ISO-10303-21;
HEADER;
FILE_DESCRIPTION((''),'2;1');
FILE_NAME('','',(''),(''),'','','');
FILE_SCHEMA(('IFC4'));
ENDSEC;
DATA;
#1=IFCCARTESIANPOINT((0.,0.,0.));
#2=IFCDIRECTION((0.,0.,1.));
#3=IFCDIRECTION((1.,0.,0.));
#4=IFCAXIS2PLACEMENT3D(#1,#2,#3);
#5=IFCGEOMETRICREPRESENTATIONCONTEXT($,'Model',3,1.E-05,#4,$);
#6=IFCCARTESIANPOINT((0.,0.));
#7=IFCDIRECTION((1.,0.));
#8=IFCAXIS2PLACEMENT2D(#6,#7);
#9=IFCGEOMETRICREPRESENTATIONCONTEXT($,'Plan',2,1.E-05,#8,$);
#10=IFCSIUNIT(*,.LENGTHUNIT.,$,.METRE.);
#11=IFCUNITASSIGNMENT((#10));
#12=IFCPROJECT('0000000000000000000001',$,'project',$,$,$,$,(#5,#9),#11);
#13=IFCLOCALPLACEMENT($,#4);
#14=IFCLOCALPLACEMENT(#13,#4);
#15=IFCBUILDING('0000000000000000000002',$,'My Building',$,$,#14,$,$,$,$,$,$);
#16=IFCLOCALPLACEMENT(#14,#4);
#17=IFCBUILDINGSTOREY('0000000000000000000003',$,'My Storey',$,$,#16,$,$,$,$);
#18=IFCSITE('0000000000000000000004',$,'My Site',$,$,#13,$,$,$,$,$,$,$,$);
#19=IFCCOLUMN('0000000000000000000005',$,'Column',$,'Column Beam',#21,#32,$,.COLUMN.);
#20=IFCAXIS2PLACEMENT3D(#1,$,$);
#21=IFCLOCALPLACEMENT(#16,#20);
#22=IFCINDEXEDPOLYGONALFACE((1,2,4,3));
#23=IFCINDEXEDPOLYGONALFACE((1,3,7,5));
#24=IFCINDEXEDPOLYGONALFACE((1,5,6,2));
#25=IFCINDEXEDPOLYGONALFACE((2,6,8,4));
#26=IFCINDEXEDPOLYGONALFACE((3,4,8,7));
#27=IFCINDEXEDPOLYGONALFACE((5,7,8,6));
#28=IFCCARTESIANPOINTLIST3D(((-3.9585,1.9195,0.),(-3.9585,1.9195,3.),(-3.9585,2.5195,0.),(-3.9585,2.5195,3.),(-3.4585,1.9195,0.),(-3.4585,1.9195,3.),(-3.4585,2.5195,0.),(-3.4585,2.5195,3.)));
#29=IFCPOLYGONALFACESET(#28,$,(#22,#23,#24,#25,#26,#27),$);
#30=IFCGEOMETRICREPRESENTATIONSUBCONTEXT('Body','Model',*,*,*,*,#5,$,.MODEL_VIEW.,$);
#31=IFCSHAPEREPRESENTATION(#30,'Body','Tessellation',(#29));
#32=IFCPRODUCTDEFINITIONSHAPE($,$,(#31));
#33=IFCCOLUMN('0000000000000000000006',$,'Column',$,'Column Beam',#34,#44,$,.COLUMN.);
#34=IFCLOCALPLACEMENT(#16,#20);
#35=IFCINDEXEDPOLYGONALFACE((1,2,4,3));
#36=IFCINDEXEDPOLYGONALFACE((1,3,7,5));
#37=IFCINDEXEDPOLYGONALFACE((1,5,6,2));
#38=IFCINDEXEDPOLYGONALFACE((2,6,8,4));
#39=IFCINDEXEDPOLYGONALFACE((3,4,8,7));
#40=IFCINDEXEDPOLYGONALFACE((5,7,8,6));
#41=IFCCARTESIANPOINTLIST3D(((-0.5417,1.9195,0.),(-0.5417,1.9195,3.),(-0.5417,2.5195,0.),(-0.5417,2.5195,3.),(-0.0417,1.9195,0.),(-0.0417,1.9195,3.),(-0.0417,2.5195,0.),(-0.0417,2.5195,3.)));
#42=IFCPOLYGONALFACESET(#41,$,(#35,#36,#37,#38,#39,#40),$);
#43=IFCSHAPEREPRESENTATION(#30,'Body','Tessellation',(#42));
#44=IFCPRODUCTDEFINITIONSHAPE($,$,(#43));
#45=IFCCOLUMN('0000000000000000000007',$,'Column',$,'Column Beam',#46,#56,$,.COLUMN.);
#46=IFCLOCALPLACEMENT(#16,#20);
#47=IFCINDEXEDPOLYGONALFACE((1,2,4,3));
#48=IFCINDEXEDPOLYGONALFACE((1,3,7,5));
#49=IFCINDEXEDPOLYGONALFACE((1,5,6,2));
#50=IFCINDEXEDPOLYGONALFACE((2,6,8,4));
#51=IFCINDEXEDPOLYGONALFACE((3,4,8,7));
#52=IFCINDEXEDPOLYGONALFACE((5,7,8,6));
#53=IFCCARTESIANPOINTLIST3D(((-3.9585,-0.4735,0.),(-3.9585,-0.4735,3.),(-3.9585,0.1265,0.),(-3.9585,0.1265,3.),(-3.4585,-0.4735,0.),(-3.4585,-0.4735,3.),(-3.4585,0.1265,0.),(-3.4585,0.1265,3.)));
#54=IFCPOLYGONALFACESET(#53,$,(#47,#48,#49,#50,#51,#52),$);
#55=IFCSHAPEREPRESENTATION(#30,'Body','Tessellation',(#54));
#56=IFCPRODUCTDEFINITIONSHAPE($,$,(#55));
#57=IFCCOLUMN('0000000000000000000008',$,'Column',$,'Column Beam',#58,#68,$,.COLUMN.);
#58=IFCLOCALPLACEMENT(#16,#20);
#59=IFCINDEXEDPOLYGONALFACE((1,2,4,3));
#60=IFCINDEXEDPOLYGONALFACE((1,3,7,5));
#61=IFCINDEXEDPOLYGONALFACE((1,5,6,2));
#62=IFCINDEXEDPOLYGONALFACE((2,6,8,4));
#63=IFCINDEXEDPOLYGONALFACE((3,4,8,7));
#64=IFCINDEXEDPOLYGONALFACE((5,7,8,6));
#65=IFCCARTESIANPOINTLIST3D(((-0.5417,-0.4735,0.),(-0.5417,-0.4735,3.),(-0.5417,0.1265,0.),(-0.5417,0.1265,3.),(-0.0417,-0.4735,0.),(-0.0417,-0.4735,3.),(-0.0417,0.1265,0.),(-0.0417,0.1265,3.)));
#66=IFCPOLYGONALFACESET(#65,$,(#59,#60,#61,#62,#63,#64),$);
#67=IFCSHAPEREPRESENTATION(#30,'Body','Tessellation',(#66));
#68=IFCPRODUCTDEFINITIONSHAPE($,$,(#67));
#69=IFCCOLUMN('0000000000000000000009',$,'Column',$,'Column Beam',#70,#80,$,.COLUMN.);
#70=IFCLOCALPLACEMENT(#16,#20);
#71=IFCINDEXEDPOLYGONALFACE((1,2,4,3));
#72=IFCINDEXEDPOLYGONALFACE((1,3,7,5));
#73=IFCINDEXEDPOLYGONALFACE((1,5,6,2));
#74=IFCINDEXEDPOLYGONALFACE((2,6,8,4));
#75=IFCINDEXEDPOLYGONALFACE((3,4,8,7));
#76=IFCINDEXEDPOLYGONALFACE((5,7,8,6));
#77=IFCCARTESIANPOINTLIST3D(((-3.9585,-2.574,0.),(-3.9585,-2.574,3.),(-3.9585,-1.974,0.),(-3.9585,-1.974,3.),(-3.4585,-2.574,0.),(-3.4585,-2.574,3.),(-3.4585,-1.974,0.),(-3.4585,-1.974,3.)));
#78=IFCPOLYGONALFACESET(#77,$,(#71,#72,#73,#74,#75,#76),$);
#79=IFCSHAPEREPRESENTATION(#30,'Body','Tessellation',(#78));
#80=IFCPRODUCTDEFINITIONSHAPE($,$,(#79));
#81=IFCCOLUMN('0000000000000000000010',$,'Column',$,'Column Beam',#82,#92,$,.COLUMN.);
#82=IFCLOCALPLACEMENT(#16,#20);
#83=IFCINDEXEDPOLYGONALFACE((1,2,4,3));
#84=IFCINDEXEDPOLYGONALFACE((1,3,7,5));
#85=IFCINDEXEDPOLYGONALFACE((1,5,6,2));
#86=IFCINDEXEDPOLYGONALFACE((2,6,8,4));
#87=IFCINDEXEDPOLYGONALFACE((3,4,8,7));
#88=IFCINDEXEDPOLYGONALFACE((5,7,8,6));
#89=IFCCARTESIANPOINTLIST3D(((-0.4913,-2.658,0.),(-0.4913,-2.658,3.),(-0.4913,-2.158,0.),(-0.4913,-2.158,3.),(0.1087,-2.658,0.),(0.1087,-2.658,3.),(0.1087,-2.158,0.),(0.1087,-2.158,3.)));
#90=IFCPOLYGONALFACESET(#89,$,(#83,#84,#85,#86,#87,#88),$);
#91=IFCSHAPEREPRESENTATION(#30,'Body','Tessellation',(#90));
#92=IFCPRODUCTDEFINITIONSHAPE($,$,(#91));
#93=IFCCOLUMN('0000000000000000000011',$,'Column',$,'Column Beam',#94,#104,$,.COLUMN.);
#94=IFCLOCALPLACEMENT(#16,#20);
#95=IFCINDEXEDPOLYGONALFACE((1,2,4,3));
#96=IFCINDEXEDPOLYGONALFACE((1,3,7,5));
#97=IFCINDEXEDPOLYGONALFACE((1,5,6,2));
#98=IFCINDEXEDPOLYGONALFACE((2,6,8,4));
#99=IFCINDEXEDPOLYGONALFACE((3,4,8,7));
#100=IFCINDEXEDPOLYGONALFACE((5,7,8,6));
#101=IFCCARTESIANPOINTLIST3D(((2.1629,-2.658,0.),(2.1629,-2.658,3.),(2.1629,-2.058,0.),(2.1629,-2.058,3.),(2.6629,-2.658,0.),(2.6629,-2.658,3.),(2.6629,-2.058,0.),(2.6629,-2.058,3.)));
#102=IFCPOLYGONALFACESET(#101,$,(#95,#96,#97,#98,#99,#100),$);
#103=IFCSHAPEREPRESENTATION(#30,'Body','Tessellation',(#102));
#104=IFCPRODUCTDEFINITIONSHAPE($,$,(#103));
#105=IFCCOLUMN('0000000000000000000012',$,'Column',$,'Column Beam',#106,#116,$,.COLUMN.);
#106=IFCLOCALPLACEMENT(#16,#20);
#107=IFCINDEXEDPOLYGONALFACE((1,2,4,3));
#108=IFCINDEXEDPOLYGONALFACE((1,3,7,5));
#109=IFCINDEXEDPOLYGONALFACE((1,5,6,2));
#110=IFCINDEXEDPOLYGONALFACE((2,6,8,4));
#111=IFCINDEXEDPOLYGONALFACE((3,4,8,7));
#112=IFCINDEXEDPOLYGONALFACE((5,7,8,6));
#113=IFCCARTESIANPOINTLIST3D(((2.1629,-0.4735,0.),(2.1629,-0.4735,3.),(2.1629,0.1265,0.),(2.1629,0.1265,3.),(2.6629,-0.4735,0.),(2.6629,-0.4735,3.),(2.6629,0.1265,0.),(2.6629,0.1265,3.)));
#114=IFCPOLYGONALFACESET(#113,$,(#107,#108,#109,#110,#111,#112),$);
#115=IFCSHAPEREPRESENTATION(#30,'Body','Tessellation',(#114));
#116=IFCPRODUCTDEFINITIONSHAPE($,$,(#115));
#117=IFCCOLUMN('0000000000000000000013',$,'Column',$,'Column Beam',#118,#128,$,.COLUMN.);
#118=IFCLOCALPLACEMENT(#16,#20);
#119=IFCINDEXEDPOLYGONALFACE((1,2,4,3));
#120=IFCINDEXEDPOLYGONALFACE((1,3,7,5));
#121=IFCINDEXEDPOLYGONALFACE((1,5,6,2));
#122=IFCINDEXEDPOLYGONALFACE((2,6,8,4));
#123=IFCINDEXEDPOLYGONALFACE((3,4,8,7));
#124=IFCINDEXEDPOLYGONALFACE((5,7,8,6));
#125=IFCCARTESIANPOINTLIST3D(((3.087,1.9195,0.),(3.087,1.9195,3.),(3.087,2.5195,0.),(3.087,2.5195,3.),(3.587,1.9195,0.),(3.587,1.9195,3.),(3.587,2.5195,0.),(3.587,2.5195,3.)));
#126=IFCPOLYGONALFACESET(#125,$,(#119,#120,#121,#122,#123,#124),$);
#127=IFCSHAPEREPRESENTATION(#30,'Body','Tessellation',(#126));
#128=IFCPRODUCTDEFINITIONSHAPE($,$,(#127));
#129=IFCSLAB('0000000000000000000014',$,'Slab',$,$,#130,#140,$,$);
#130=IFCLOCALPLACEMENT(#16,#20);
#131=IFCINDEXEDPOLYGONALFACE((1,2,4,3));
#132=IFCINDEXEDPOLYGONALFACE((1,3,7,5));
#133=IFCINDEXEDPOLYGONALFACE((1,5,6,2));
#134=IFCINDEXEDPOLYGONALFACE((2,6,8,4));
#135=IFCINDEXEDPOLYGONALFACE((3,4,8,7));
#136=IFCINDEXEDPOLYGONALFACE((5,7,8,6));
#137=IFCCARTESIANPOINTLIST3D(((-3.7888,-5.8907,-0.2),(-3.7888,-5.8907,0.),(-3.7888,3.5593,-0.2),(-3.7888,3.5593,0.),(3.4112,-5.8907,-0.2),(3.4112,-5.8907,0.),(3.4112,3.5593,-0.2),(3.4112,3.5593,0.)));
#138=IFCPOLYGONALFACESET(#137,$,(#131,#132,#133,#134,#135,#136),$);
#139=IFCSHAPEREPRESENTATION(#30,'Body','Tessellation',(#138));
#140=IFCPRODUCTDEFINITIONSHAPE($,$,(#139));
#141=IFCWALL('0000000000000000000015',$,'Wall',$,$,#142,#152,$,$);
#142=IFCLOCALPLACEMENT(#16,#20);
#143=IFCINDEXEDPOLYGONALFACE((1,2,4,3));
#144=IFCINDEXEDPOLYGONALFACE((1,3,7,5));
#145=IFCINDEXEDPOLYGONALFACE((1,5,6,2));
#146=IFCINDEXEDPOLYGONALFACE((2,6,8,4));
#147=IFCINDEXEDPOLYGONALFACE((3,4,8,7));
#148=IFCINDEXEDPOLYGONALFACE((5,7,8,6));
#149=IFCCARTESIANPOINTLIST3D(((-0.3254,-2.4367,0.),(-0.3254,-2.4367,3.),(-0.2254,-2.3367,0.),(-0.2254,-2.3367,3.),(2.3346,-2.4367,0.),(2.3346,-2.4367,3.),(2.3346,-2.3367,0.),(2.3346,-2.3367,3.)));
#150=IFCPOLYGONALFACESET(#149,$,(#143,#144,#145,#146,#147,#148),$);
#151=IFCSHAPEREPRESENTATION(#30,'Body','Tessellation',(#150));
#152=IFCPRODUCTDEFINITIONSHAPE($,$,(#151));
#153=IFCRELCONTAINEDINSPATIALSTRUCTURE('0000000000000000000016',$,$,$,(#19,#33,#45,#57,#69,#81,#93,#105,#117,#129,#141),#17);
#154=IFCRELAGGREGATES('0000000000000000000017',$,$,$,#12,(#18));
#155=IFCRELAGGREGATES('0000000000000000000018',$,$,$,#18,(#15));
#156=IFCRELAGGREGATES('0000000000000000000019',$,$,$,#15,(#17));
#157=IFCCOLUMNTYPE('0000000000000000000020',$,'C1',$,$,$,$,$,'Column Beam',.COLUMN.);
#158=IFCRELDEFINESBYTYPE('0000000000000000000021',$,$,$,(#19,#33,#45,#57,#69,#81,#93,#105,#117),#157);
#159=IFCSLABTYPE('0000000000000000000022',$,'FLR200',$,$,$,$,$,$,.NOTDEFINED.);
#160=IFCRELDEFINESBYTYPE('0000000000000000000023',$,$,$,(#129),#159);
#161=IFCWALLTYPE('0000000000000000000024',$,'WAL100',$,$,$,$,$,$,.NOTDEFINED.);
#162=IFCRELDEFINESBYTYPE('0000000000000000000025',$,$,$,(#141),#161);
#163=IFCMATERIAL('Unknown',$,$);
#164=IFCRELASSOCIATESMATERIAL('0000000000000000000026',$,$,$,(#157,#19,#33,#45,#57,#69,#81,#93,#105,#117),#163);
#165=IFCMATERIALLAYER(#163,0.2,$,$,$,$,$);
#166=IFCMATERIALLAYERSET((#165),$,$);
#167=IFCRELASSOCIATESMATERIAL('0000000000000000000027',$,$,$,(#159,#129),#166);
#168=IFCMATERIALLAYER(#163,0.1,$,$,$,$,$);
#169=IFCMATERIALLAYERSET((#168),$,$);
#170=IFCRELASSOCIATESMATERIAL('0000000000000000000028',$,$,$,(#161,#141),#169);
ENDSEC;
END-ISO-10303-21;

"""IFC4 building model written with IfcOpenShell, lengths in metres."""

from ifc_helpers import new_model, si_unit, frame, origin_with_axes, origin_2d_with_axis, place, context, subcontext, project, spatial, line, indexed_curve, outline, extrude, material, layer, layer_set, layer_usage, material_profile, profile_set, profile_usage, type_object, element, save


model = new_model("IFC4")

# Units and contexts
model_context = context("Model", 3, precision=1e-05, world=origin_with_axes())
plan_context = context("Plan", 2, precision=1e-05, world=origin_2d_with_axis())
body_context_1 = subcontext(model_context, "Body", "Model", "MODEL_VIEW")
ifc_project = project(units=[si_unit("LENGTHUNIT", "METRE")], contexts=[model_context, plan_context])

# Site, building, storey
site_placement = place(None, origin_with_axes())
site = spatial("IfcSite", under=ifc_project, at=site_placement, Name="My Site")
building_placement = place(site_placement, origin_with_axes())
building = spatial("IfcBuilding", under=site, at=building_placement, Name="My Building")
storey_placement = place(building_placement, origin_with_axes())
storey = spatial("IfcBuildingStorey", under=building, at=storey_placement, Name="My Storey")

# Columns
ifc_material = material(Name="Unknown")
ifc_material_profile = material_profile(ifc_material, outline(indexed_curve([(-0.25, -0.3), (0.25, -0.3), (0.25, 0.3), (-0.25, 0.3), (-0.25, -0.3)])))
ifc_profile_set = profile_set([ifc_material_profile])
ifc_profile_usage_1 = profile_usage(ifc_profile_set, cardinal=5)
column_type = type_object("IfcColumnType", Name="C1", ElementType="Column Beam", PredefinedType="COLUMN", material=ifc_profile_set)
column_1_placement = place(storey_placement, frame((-3.7085, 2.2195, 0.0), z_axis=(0.0, 0.0, 1.0), x_axis=(1.0, 0.0, 0.0)))
element("IfcColumn", 1, at=column_1_placement, inside=storey, type_object=column_type, material=ifc_profile_usage_1, Name="Column", ObjectType="Column Beam", PredefinedType="COLUMN", context=body_context_1, shape_type="SweptSolid", body=[
    extrude(outline(indexed_curve([(-0.25, -0.3), (0.25, -0.3), (0.25, 0.3), (-0.25, 0.3), (-0.25, -0.3)])), origin_with_axes(), (0.0, 0.0, 1.0), 3.0),
])
ifc_profile_usage_2 = profile_usage(ifc_profile_set, cardinal=5)
column_2_placement = place(storey_placement, frame((-0.2917, 2.2195, 0.0), z_axis=(0.0, 0.0, 1.0), x_axis=(1.0, 0.0, 0.0)))
element("IfcColumn", 2, at=column_2_placement, inside=storey, type_object=column_type, material=ifc_profile_usage_2, Name="Column", ObjectType="Column Beam", PredefinedType="COLUMN", context=body_context_1, shape_type="SweptSolid", body=[
    extrude(outline(indexed_curve([(-0.25, -0.3), (0.25, -0.3), (0.25, 0.3), (-0.25, 0.3), (-0.25, -0.3)])), origin_with_axes(), (0.0, 0.0, 1.0), 3.0),
])
ifc_profile_usage_3 = profile_usage(ifc_profile_set, cardinal=5)
column_3_placement = place(storey_placement, frame((-3.7085, -0.1735, 0.0), z_axis=(0.0, 0.0, 1.0), x_axis=(1.0, 0.0, 0.0)))
element("IfcColumn", 3, at=column_3_placement, inside=storey, type_object=column_type, material=ifc_profile_usage_3, Name="Column", ObjectType="Column Beam", PredefinedType="COLUMN", context=body_context_1, shape_type="SweptSolid", body=[
    extrude(outline(indexed_curve([(-0.25, -0.3), (0.25, -0.3), (0.25, 0.3), (-0.25, 0.3), (-0.25, -0.3)])), origin_with_axes(), (0.0, 0.0, 1.0), 3.0),
])
ifc_profile_usage_4 = profile_usage(ifc_profile_set, cardinal=5)
column_4_placement = place(storey_placement, frame((-0.2917, -0.1735, 0.0), z_axis=(0.0, 0.0, 1.0), x_axis=(1.0, 0.0, 0.0)))
element("IfcColumn", 4, at=column_4_placement, inside=storey, type_object=column_type, material=ifc_profile_usage_4, Name="Column", ObjectType="Column Beam", PredefinedType="COLUMN", context=body_context_1, shape_type="SweptSolid", body=[
    extrude(outline(indexed_curve([(-0.25, -0.3), (0.25, -0.3), (0.25, 0.3), (-0.25, 0.3), (-0.25, -0.3)])), origin_with_axes(), (0.0, 0.0, 1.0), 3.0),
])
ifc_profile_usage_5 = profile_usage(ifc_profile_set, cardinal=5)
column_5_placement = place(storey_placement, frame((-3.7085, -2.274, 0.0), z_axis=(0.0, 0.0, 1.0), x_axis=(1.0, 0.0, 0.0)))
element("IfcColumn", 5, at=column_5_placement, inside=storey, type_object=column_type, material=ifc_profile_usage_5, Name="Column", ObjectType="Column Beam", PredefinedType="COLUMN", context=body_context_1, shape_type="SweptSolid", body=[
    extrude(outline(indexed_curve([(-0.25, -0.3), (0.25, -0.3), (0.25, 0.3), (-0.25, 0.3), (-0.25, -0.3)])), origin_with_axes(), (0.0, 0.0, 1.0), 3.0),
])
ifc_profile_usage_6 = profile_usage(ifc_profile_set, cardinal=5)
column_6_placement = place(storey_placement, frame((-0.1913, -2.408, 0.0), z_axis=(0.0, 0.0, 1.0), x_axis=(0.0, 1.0, 0.0)))
element("IfcColumn", 6, at=column_6_placement, inside=storey, type_object=column_type, material=ifc_profile_usage_6, Name="Column", ObjectType="Column Beam", PredefinedType="COLUMN", context=body_context_1, shape_type="SweptSolid", body=[
    extrude(outline(indexed_curve([(-0.25, -0.3), (0.25, -0.3), (0.25, 0.3), (-0.25, 0.3), (-0.25, -0.3)])), origin_with_axes(), (0.0, 0.0, 1.0), 3.0),
])
ifc_profile_usage_7 = profile_usage(ifc_profile_set, cardinal=5)
column_7_placement = place(storey_placement, frame((2.4129, -2.358, 0.0), z_axis=(0.0, 0.0, 1.0), x_axis=(1.0, 0.0, 0.0)))
element("IfcColumn", 7, at=column_7_placement, inside=storey, type_object=column_type, material=ifc_profile_usage_7, Name="Column", ObjectType="Column Beam", PredefinedType="COLUMN", context=body_context_1, shape_type="SweptSolid", body=[
    extrude(outline(indexed_curve([(-0.25, -0.3), (0.25, -0.3), (0.25, 0.3), (-0.25, 0.3), (-0.25, -0.3)])), origin_with_axes(), (0.0, 0.0, 1.0), 3.0),
])
ifc_profile_usage_8 = profile_usage(ifc_profile_set, cardinal=5)
column_8_placement = place(storey_placement, frame((2.4129, -0.1735, 0.0), z_axis=(0.0, 0.0, 1.0), x_axis=(1.0, 0.0, 0.0)))
element("IfcColumn", 8, at=column_8_placement, inside=storey, type_object=column_type, material=ifc_profile_usage_8, Name="Column", ObjectType="Column Beam", PredefinedType="COLUMN", context=body_context_1, shape_type="SweptSolid", body=[
    extrude(outline(indexed_curve([(-0.25, -0.3), (0.25, -0.3), (0.25, 0.3), (-0.25, 0.3), (-0.25, -0.3)])), origin_with_axes(), (0.0, 0.0, 1.0), 3.0),
])
ifc_profile_usage_9 = profile_usage(ifc_profile_set, cardinal=5)
column_9_placement = place(storey_placement, frame((3.337, 2.2195, 0.0), z_axis=(0.0, 0.0, 1.0), x_axis=(1.0, 0.0, 0.0)))
element("IfcColumn", 9, at=column_9_placement, inside=storey, type_object=column_type, material=ifc_profile_usage_9, Name="Column", ObjectType="Column Beam", PredefinedType="COLUMN", context=body_context_1, shape_type="SweptSolid", body=[
    extrude(outline(indexed_curve([(-0.25, -0.3), (0.25, -0.3), (0.25, 0.3), (-0.25, 0.3), (-0.25, -0.3)])), origin_with_axes(), (0.0, 0.0, 1.0), 3.0),
])

# Slab
ifc_layer_1 = layer(ifc_material, 0.2)
ifc_layer_set_1 = layer_set([ifc_layer_1])
ifc_layer_usage_1 = layer_usage(ifc_layer_set_1, "AXIS3", "POSITIVE", -0.2)
slab_type = type_object("IfcSlabType", Name="FLR200", PredefinedType="NOTDEFINED", material=ifc_layer_set_1)
slab_placement = place(storey_placement, frame((-3.7888, 3.5593, 0.0), z_axis=(0.0, 0.0, 1.0), x_axis=(1.0, 0.0, 0.0)))
element("IfcSlab", 10, at=slab_placement, inside=storey, type_object=slab_type, material=ifc_layer_usage_1, Name="Slab", context=body_context_1, shape_type="SweptSolid", body=[
    extrude(outline(indexed_curve([(0.0, 0.0), (7.2, 0.0), (7.2, -9.45), (0.0, -9.45), (0.0, 0.0)])), frame((0.0, 0.0, -0.2), z_axis=(0.0, 0.0, 1.0), x_axis=(1.0, 0.0, 0.0)), (0.0, 0.0, 1.0), 0.2),
])

# Wall
ifc_layer_2 = layer(ifc_material, 0.1)
ifc_layer_set_2 = layer_set([ifc_layer_2])
ifc_layer_usage_2 = layer_usage(ifc_layer_set_2, "AXIS2", "POSITIVE", 0.0)
wall_type_1 = type_object("IfcWallType", Name="WAL100", PredefinedType="NOTDEFINED", material=ifc_layer_set_2)
wall_1_placement = place(storey_placement, frame((2.3346, -2.3367, 0.0), z_axis=(0.0, 0.0, 1.0), x_axis=(-1.0, 0.0, 0.0)))
element("IfcWall", 11, at=wall_1_placement, inside=storey, type_object=wall_type_1, material=ifc_layer_usage_2, Name="Wall", context=body_context_1, shape_type="SweptSolid", body=[
    extrude(outline(indexed_curve([(0.0, 0.0), (0.0, 0.1), (2.66, 0.1), (2.56, 0.0)], segments=[line(1, 2, 3, 4, 1)])), origin_with_axes(), (0.0, 0.0, 1.0), 3.0),
])

save(model, "model.ifc")
